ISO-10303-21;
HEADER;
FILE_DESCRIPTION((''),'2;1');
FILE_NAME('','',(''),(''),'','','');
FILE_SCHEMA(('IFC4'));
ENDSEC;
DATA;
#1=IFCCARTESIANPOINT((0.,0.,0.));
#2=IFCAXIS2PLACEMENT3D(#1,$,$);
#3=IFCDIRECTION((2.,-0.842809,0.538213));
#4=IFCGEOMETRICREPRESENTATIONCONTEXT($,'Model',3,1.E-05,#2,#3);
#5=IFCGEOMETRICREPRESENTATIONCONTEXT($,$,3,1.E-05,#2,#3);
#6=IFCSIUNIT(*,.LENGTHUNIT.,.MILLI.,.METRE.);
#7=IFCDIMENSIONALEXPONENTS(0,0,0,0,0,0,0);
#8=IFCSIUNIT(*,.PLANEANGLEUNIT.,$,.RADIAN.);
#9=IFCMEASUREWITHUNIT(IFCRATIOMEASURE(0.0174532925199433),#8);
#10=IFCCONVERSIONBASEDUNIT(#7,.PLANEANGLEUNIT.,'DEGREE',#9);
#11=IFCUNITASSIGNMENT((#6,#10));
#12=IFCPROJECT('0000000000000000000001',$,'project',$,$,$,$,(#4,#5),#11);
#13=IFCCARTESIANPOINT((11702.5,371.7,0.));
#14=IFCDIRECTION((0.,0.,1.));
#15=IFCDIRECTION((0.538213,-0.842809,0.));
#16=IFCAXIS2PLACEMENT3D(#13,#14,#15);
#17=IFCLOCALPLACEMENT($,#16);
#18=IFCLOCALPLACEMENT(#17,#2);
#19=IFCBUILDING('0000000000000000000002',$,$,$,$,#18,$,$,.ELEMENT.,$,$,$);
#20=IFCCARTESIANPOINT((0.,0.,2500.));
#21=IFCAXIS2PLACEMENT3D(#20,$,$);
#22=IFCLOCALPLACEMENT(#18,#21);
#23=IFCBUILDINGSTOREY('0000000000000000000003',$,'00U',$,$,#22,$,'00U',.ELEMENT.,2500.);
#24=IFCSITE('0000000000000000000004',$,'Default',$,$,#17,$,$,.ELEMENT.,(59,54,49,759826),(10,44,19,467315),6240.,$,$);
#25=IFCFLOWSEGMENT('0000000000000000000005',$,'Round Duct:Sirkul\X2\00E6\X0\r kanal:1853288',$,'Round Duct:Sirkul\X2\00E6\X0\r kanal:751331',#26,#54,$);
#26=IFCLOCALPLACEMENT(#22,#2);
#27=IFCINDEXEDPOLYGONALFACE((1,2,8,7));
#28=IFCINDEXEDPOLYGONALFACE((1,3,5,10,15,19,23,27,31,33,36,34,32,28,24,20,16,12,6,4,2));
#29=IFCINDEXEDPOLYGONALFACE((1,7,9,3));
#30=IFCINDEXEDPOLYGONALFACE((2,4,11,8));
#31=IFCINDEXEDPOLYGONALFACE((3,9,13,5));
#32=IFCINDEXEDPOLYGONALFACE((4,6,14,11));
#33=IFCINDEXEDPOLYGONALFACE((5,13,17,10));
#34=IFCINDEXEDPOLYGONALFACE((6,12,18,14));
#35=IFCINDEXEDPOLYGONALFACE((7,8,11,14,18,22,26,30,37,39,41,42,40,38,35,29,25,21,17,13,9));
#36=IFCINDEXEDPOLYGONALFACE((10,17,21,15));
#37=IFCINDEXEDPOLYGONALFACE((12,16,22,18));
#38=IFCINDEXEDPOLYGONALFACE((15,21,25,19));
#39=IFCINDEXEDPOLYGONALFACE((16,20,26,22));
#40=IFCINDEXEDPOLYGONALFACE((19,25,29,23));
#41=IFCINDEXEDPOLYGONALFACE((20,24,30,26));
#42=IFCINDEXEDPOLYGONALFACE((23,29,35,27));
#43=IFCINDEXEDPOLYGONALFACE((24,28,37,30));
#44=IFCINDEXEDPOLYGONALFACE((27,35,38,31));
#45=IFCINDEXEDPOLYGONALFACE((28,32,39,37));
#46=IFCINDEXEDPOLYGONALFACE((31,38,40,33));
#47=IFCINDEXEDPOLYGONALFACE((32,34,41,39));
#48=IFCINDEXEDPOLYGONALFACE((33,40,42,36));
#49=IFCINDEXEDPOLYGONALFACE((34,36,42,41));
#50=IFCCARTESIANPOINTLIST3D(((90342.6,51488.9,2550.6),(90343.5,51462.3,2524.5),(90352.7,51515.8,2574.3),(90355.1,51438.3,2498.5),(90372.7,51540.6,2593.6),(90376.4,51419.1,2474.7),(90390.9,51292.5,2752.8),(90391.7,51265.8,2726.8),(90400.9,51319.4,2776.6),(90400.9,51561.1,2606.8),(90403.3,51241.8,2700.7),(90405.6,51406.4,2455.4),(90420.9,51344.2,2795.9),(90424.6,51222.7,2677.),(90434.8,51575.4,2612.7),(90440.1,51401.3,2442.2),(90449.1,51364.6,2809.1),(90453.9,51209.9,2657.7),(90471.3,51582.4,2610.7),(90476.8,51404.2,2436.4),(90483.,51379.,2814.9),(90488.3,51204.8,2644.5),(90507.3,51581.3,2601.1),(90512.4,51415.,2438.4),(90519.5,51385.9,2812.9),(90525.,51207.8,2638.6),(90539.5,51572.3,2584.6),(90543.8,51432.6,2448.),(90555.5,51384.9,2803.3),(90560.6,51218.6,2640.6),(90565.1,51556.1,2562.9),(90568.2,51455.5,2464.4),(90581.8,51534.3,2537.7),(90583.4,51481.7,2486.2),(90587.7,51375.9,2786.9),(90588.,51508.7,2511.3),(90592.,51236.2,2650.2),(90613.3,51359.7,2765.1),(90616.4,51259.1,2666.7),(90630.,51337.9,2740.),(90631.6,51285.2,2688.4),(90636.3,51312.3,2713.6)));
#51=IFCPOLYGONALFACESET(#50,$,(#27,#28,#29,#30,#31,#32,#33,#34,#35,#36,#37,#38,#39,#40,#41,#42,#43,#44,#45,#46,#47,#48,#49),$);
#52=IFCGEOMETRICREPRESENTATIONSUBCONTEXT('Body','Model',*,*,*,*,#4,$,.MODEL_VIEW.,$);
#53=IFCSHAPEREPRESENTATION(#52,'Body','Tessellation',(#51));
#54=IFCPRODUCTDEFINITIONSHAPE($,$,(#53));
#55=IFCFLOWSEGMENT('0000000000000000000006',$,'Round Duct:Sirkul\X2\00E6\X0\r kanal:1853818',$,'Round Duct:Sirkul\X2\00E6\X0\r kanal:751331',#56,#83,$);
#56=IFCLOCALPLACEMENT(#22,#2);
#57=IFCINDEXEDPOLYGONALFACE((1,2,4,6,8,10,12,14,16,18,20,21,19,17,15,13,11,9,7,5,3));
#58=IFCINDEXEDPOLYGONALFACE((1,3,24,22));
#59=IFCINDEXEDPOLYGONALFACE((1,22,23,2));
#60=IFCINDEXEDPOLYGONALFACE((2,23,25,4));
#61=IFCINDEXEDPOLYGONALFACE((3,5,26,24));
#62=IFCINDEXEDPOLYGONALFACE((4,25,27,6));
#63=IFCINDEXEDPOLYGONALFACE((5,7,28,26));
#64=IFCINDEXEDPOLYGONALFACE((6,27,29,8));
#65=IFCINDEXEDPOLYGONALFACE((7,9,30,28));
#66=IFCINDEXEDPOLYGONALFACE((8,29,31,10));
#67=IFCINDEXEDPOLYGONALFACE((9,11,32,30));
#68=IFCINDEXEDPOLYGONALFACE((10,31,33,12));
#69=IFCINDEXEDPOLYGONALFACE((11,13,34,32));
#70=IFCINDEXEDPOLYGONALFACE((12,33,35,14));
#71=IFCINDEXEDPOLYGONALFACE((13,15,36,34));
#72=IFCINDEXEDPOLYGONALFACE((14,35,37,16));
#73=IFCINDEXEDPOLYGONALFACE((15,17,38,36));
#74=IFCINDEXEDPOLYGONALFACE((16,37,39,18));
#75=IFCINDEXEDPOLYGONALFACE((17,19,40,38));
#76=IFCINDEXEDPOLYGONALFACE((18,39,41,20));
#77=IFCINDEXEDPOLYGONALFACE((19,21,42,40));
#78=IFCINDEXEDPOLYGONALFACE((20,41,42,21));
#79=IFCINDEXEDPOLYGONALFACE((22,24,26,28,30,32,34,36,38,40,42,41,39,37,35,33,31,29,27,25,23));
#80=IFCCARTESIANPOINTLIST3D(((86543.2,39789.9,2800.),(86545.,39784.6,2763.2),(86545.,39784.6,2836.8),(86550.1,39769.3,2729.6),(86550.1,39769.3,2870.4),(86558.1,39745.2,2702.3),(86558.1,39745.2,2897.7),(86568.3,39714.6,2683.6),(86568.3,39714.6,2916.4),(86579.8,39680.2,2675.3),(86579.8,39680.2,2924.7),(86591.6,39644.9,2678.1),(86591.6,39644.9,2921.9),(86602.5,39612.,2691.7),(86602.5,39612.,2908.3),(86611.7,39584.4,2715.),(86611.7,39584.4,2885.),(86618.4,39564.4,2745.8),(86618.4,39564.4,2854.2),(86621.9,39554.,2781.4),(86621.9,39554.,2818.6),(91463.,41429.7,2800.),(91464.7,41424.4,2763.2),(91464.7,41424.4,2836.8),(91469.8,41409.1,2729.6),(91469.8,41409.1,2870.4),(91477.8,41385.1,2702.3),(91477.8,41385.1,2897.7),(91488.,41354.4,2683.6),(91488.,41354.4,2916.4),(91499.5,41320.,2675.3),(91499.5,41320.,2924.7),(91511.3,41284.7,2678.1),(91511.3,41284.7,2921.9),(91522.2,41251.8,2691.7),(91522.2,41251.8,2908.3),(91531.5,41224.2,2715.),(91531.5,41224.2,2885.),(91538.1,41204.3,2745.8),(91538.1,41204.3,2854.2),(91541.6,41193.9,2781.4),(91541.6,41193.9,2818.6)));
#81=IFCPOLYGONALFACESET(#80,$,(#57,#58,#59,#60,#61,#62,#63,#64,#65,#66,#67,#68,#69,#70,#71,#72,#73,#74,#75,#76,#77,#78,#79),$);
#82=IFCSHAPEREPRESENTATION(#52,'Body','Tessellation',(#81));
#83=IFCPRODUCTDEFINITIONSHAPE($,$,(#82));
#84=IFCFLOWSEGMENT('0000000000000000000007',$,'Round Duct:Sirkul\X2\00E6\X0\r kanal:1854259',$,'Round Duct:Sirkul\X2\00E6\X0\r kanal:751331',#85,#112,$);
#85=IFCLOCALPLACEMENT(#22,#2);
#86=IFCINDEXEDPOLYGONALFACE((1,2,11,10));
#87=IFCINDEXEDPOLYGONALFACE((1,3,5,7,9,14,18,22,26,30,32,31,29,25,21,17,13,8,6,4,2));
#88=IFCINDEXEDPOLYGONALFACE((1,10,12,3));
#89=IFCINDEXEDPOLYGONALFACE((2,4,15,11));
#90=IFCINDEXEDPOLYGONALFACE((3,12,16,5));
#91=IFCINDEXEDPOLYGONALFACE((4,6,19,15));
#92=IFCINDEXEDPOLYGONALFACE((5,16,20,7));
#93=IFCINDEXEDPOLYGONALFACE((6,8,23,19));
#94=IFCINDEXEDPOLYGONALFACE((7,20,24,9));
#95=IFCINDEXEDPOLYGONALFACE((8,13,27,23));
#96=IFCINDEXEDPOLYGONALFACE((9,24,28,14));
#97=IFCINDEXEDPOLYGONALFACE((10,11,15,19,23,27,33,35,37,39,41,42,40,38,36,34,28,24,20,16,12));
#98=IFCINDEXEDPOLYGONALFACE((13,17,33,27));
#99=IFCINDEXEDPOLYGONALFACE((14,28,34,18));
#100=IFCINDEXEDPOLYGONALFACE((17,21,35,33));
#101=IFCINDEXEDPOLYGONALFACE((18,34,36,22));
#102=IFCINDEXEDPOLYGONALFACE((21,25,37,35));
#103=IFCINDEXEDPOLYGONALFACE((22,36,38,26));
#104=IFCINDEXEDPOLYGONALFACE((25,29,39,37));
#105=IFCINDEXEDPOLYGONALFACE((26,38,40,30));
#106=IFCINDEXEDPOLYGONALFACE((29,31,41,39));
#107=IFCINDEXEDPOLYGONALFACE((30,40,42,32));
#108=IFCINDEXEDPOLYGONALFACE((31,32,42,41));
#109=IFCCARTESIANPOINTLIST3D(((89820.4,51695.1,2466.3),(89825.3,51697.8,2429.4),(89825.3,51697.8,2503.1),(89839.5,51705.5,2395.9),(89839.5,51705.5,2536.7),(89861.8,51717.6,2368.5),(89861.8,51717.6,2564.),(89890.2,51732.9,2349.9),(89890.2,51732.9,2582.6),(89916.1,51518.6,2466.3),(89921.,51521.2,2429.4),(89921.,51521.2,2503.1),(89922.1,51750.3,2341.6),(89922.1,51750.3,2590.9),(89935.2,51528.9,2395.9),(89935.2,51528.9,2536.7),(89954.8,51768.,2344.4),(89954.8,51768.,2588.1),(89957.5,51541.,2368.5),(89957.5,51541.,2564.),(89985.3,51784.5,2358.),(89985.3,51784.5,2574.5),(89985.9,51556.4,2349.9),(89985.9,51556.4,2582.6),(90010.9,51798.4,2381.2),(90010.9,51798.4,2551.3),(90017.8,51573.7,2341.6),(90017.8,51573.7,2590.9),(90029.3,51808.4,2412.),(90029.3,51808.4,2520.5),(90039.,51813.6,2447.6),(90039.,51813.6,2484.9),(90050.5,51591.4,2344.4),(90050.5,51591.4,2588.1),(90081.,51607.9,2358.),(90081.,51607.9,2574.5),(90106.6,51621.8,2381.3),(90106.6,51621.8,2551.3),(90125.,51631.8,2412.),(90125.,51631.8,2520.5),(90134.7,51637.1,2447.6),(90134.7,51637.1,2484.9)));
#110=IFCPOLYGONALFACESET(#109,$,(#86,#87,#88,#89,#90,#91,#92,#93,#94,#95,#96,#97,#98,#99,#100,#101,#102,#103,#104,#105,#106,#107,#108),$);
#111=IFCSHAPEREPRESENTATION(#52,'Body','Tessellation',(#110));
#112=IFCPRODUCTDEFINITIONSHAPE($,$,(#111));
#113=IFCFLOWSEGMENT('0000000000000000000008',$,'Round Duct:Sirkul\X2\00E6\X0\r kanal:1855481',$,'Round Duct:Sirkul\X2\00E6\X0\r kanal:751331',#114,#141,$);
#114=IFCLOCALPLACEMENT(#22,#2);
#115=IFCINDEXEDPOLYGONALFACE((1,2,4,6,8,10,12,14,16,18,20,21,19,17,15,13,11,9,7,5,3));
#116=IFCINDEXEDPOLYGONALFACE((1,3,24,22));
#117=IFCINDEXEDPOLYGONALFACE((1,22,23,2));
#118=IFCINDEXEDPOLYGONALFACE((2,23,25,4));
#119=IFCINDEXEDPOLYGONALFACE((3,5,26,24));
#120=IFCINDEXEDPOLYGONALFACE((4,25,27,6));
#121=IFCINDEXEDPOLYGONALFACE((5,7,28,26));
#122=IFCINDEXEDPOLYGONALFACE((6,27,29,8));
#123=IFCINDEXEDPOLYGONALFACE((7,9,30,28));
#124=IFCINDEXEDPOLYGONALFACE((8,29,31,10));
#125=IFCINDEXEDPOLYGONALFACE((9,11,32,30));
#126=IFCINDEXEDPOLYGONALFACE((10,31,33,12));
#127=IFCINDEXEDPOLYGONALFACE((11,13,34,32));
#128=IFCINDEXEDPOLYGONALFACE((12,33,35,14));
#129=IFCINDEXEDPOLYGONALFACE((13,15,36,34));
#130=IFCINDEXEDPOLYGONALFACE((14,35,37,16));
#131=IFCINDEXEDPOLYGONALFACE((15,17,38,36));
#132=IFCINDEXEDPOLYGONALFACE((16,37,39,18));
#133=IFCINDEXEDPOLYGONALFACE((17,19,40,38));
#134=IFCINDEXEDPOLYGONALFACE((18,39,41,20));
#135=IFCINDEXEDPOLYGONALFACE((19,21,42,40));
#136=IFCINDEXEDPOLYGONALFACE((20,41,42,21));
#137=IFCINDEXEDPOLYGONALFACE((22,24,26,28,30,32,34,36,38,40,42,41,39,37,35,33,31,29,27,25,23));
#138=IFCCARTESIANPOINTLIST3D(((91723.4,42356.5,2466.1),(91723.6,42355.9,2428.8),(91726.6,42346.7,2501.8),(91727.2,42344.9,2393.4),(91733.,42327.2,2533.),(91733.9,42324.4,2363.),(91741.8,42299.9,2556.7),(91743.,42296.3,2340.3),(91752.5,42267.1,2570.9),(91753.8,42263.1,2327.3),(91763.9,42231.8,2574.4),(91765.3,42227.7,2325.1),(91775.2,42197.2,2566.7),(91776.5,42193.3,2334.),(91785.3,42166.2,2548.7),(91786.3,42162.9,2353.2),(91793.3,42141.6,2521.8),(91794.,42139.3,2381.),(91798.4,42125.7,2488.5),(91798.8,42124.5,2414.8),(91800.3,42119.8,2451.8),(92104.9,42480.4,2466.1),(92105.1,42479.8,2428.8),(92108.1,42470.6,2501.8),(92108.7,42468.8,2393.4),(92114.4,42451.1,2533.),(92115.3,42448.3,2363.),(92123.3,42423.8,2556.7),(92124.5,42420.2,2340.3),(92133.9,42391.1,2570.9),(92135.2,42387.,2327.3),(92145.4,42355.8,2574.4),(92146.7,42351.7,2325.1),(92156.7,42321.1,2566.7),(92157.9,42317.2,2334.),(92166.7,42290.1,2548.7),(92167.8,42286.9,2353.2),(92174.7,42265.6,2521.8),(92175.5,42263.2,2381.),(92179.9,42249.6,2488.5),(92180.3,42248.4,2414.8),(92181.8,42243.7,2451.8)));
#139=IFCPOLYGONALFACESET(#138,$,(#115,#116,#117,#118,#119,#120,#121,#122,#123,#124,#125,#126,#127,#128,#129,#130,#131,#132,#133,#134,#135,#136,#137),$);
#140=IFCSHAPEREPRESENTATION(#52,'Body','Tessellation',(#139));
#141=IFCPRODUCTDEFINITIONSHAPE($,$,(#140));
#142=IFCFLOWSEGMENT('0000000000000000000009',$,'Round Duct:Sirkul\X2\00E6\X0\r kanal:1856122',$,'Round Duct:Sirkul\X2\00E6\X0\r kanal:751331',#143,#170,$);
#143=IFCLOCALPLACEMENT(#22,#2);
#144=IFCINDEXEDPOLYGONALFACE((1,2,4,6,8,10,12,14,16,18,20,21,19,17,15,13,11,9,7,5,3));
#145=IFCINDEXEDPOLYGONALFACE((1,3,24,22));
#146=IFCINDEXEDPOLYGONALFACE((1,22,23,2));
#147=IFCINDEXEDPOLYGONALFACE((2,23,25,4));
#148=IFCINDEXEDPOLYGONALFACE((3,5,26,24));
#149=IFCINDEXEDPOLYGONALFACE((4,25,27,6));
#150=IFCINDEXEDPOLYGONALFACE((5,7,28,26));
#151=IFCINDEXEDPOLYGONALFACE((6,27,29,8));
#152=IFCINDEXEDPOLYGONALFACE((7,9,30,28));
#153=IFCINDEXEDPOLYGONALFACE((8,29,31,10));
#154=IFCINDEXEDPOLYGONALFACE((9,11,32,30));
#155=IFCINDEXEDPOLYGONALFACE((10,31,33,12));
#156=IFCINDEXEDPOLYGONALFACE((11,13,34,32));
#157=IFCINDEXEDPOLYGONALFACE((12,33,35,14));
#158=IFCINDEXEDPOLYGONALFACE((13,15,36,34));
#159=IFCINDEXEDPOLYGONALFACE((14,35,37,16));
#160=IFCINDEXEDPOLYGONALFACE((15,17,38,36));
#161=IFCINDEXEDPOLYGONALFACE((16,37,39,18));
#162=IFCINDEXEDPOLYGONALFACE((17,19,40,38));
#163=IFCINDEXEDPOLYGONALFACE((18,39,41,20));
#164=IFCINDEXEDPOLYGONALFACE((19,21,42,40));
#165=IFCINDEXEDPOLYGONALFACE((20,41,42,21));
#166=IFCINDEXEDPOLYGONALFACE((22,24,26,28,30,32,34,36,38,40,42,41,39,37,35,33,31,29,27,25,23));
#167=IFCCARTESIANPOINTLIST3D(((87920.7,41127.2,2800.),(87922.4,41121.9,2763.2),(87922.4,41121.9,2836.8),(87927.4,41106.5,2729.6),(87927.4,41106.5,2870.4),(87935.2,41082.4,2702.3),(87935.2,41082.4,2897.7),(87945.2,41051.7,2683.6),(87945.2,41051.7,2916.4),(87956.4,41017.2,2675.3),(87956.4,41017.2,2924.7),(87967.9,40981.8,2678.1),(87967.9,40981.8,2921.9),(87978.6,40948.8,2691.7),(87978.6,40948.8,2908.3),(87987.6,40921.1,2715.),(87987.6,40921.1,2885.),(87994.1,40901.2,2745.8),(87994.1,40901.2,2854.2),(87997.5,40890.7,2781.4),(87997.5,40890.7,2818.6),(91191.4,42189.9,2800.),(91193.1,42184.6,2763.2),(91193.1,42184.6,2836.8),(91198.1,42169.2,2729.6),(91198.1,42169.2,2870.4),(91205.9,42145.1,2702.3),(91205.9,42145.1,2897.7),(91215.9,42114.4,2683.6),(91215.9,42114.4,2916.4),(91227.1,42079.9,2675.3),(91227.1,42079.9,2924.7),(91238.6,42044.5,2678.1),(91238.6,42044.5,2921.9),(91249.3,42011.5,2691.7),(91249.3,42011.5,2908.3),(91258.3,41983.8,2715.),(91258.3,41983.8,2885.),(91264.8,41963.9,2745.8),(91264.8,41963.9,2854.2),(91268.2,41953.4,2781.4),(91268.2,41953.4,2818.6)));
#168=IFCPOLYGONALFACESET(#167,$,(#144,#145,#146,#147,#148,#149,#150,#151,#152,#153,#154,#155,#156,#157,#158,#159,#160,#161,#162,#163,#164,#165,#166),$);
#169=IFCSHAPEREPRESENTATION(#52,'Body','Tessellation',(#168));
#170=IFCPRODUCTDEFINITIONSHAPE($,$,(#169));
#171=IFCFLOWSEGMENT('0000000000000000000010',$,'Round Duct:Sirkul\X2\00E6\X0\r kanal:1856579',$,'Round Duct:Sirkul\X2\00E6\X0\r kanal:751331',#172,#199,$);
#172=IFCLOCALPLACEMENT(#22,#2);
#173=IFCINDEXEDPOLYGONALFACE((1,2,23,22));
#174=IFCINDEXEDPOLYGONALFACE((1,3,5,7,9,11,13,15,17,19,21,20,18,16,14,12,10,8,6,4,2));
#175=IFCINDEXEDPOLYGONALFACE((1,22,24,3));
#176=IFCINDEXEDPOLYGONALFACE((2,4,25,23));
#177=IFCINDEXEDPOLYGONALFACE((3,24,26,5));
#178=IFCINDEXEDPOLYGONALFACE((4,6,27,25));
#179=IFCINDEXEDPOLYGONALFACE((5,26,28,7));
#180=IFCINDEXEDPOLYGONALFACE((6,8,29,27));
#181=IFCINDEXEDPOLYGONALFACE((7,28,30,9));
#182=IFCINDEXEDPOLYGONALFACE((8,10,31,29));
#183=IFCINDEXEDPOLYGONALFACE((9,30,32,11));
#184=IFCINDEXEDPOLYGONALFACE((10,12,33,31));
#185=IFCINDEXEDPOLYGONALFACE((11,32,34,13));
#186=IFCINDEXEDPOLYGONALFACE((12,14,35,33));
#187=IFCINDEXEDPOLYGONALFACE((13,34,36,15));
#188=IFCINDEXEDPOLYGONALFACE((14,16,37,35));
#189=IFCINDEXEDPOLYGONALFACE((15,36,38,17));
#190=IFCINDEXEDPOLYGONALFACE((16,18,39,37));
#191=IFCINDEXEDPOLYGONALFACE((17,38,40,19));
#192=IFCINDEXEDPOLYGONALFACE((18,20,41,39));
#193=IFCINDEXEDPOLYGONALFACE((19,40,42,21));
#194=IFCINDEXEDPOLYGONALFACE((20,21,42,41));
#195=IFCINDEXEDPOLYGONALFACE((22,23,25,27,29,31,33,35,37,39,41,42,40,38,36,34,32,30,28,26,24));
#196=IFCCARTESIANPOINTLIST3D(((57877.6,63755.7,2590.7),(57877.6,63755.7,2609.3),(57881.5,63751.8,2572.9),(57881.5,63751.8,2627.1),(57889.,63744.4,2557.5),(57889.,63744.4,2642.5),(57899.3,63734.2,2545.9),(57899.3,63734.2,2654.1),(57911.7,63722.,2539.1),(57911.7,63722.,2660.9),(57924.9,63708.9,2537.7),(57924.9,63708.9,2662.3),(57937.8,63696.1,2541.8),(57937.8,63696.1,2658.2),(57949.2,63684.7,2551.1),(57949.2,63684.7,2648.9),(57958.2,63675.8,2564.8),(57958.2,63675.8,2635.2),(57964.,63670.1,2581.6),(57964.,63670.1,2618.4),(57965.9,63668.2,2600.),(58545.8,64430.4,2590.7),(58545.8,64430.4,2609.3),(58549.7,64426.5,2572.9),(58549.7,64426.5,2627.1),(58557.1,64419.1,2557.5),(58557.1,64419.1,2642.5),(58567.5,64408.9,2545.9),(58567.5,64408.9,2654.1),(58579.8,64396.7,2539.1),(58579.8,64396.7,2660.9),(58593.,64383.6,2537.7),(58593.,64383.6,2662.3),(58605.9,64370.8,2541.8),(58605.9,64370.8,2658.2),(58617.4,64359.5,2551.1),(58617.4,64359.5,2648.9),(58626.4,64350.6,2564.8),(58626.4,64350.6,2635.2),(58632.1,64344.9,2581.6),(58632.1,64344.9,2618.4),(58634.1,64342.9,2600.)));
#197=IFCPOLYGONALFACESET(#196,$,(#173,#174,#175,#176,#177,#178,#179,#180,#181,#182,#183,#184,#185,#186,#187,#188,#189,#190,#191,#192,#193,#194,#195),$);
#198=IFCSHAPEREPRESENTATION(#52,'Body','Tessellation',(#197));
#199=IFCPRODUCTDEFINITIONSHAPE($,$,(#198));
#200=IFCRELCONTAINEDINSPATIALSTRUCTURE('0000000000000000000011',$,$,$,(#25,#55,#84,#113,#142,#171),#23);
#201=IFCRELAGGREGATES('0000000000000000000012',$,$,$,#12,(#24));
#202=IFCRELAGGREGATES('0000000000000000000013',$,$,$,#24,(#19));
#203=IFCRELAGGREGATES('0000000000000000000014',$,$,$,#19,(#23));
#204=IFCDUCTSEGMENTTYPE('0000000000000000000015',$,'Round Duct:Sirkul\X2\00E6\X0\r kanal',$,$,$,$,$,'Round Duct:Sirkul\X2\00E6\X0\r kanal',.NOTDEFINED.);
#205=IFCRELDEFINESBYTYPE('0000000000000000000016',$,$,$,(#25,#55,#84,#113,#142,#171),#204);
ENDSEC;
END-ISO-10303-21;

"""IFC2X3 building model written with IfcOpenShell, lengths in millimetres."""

from ifc_helpers import new_model, entity, si_unit, converted_unit, direction, frame, frame_2d, origin, origin_2d_with_axis, place, context, subcontext, project, spatial, circle, extrude, type_object, element, save


model = new_model("IFC2X3")

# Units and contexts
model_context = context("Model", 3, precision=1e-05, world=origin(), true_north=direction((2.0, -0.842809, 0.538213)))
context_of_model = context(None, 3, precision=1e-05, world=origin(), true_north=direction((2.0, -0.842809, 0.538213)))
body_context = subcontext(model_context, "Body", "Model", "MODEL_VIEW")
ifc_project = project(units=[si_unit("LENGTHUNIT", "METRE", prefix="MILLI"), converted_unit("PLANEANGLEUNIT", "DEGREE", entity("IfcRatioMeasure", 0.0174532925199433), si_unit("PLANEANGLEUNIT", "RADIAN"), dimensions=[0, 0, 0, 0, 0, 0, 0])], contexts=[model_context, context_of_model])

# Site, building, storey
site_placement = place(None, frame((11702.5, 371.7, 0.0), z_axis=(0.0, 0.0, 1.0), x_axis=(0.538213, -0.842809, 0.0)))
site = spatial("IfcSite", under=ifc_project, at=site_placement, Name="Default", CompositionType="ELEMENT", RefLatitude=(59, 54, 49, 759826), RefLongitude=(10, 44, 19, 467315), RefElevation=6240.0)
building_placement = place(site_placement, origin())
building = spatial("IfcBuilding", under=site, at=building_placement, CompositionType="ELEMENT")
storey_placement = place(building_placement, frame((0.0, 0.0, 2500.0)))
storey = spatial("IfcBuildingStorey", under=building, at=storey_placement, Name="00U", LongName="00U", CompositionType="ELEMENT", Elevation=2500.0)

# Flow segments
duct_segment_type = type_object("IfcDuctSegmentType", Name="Round Duct:Sirkulær kanal", ElementType="Round Duct:Sirkulær kanal", PredefinedType="NOTDEFINED")
flow_segment_1_placement = place(storey_placement, origin())
element("IfcFlowSegment", 1, at=flow_segment_1_placement, inside=storey, type_object=duct_segment_type, Name="Round Duct:Sirkulær kanal:1853288", ObjectType="Round Duct:Sirkulær kanal:751331", context=body_context, shape_type="SweptSolid", body=[
    extrude(circle(Radius=125.0, at=origin_2d_with_axis()), frame((90464.9, 51492.0, 2524.5), z_axis=(0.168561, -0.686722, 0.707107), x_axis=(-0.971172, -0.238381, 0.0)), (0.0, 0.0, 1.0), 286.0),
])
flow_segment_2_placement = place(storey_placement, origin())
element("IfcFlowSegment", 2, at=flow_segment_2_placement, inside=storey, type_object=duct_segment_type, Name="Round Duct:Sirkulær kanal:1853818", ObjectType="Round Duct:Sirkulær kanal:751331", context=body_context, shape_type="SweptSolid", body=[
    extrude(circle(Radius=125.0, at=origin_2d_with_axis()), frame((86582.8, 39671.3, 2800.0), z_axis=(0.948688, 0.316215, 0.0), x_axis=(-0.316215, 0.948688, 0.0)), (0.0, 0.0, 1.0), 5185.8),
])
flow_segment_3_placement = place(storey_placement, origin())
element("IfcFlowSegment", 3, at=flow_segment_3_placement, inside=storey, type_object=duct_segment_type, Name="Round Duct:Sirkulær kanal:1854259", ObjectType="Round Duct:Sirkulær kanal:751331", context=body_context, shape_type="SweptSolid", body=[
    extrude(circle(Radius=125.0, at=origin_2d_with_axis()), frame((89930.3, 51754.7, 2466.3), z_axis=(0.476613, -0.879113, 0.000017), x_axis=(-0.879113, -0.476613, 0.0)), (0.0, 0.0, 1.0), 200.8),
])
flow_segment_4_placement = place(storey_placement, origin())
element("IfcFlowSegment", 4, at=flow_segment_4_placement, inside=storey, type_object=duct_segment_type, Name="Round Duct:Sirkulær kanal:1855481", ObjectType="Round Duct:Sirkulær kanal:751331", context=body_context, shape_type="SweptSolid", body=[
    extrude(circle(Radius=125.0, at=origin_2d_with_axis()), frame((91761.7, 42238.7, 2449.6), z_axis=(0.951057, 0.309017, 0.0), x_axis=(0.30897, -0.950912, 0.01745)), (0.0, 0.0, 1.0), 401.1),
])
flow_segment_5_placement = place(storey_placement, origin())
element("IfcFlowSegment", 5, at=flow_segment_5_placement, inside=storey, type_object=duct_segment_type, Name="Round Duct:Sirkulær kanal:1856122", ObjectType="Round Duct:Sirkulær kanal:751331", context=body_context, shape_type="SweptSolid", body=[
    extrude(circle(Radius=125.0, at=origin_2d_with_axis()), frame((87959.3, 41008.3, 2800.0), z_axis=(0.951057, 0.309014, 0.0), x_axis=(-0.309014, 0.951057, 0.0)), (0.0, 0.0, 1.0), 3439.0),
])
flow_segment_6_placement = place(storey_placement, origin())
element("IfcFlowSegment", 6, at=flow_segment_6_placement, inside=storey, type_object=duct_segment_type, Name="Round Duct:Sirkulær kanal:1856579", ObjectType="Round Duct:Sirkulær kanal:751331", context=body_context, shape_type="SweptSolid", body=[
    extrude(circle(Radius=62.5, at=frame_2d((0.0, 0.0), x_axis=(1.0, 0.0))), frame((57921.5, 63712.2, 2600.0), z_axis=(0.703631, 0.710566, 0.0), x_axis=(0.710566, -0.703631, 0.0)), (0.0, 0.0, 1.0), 949.6),
])

save(model, "model.ifc")
